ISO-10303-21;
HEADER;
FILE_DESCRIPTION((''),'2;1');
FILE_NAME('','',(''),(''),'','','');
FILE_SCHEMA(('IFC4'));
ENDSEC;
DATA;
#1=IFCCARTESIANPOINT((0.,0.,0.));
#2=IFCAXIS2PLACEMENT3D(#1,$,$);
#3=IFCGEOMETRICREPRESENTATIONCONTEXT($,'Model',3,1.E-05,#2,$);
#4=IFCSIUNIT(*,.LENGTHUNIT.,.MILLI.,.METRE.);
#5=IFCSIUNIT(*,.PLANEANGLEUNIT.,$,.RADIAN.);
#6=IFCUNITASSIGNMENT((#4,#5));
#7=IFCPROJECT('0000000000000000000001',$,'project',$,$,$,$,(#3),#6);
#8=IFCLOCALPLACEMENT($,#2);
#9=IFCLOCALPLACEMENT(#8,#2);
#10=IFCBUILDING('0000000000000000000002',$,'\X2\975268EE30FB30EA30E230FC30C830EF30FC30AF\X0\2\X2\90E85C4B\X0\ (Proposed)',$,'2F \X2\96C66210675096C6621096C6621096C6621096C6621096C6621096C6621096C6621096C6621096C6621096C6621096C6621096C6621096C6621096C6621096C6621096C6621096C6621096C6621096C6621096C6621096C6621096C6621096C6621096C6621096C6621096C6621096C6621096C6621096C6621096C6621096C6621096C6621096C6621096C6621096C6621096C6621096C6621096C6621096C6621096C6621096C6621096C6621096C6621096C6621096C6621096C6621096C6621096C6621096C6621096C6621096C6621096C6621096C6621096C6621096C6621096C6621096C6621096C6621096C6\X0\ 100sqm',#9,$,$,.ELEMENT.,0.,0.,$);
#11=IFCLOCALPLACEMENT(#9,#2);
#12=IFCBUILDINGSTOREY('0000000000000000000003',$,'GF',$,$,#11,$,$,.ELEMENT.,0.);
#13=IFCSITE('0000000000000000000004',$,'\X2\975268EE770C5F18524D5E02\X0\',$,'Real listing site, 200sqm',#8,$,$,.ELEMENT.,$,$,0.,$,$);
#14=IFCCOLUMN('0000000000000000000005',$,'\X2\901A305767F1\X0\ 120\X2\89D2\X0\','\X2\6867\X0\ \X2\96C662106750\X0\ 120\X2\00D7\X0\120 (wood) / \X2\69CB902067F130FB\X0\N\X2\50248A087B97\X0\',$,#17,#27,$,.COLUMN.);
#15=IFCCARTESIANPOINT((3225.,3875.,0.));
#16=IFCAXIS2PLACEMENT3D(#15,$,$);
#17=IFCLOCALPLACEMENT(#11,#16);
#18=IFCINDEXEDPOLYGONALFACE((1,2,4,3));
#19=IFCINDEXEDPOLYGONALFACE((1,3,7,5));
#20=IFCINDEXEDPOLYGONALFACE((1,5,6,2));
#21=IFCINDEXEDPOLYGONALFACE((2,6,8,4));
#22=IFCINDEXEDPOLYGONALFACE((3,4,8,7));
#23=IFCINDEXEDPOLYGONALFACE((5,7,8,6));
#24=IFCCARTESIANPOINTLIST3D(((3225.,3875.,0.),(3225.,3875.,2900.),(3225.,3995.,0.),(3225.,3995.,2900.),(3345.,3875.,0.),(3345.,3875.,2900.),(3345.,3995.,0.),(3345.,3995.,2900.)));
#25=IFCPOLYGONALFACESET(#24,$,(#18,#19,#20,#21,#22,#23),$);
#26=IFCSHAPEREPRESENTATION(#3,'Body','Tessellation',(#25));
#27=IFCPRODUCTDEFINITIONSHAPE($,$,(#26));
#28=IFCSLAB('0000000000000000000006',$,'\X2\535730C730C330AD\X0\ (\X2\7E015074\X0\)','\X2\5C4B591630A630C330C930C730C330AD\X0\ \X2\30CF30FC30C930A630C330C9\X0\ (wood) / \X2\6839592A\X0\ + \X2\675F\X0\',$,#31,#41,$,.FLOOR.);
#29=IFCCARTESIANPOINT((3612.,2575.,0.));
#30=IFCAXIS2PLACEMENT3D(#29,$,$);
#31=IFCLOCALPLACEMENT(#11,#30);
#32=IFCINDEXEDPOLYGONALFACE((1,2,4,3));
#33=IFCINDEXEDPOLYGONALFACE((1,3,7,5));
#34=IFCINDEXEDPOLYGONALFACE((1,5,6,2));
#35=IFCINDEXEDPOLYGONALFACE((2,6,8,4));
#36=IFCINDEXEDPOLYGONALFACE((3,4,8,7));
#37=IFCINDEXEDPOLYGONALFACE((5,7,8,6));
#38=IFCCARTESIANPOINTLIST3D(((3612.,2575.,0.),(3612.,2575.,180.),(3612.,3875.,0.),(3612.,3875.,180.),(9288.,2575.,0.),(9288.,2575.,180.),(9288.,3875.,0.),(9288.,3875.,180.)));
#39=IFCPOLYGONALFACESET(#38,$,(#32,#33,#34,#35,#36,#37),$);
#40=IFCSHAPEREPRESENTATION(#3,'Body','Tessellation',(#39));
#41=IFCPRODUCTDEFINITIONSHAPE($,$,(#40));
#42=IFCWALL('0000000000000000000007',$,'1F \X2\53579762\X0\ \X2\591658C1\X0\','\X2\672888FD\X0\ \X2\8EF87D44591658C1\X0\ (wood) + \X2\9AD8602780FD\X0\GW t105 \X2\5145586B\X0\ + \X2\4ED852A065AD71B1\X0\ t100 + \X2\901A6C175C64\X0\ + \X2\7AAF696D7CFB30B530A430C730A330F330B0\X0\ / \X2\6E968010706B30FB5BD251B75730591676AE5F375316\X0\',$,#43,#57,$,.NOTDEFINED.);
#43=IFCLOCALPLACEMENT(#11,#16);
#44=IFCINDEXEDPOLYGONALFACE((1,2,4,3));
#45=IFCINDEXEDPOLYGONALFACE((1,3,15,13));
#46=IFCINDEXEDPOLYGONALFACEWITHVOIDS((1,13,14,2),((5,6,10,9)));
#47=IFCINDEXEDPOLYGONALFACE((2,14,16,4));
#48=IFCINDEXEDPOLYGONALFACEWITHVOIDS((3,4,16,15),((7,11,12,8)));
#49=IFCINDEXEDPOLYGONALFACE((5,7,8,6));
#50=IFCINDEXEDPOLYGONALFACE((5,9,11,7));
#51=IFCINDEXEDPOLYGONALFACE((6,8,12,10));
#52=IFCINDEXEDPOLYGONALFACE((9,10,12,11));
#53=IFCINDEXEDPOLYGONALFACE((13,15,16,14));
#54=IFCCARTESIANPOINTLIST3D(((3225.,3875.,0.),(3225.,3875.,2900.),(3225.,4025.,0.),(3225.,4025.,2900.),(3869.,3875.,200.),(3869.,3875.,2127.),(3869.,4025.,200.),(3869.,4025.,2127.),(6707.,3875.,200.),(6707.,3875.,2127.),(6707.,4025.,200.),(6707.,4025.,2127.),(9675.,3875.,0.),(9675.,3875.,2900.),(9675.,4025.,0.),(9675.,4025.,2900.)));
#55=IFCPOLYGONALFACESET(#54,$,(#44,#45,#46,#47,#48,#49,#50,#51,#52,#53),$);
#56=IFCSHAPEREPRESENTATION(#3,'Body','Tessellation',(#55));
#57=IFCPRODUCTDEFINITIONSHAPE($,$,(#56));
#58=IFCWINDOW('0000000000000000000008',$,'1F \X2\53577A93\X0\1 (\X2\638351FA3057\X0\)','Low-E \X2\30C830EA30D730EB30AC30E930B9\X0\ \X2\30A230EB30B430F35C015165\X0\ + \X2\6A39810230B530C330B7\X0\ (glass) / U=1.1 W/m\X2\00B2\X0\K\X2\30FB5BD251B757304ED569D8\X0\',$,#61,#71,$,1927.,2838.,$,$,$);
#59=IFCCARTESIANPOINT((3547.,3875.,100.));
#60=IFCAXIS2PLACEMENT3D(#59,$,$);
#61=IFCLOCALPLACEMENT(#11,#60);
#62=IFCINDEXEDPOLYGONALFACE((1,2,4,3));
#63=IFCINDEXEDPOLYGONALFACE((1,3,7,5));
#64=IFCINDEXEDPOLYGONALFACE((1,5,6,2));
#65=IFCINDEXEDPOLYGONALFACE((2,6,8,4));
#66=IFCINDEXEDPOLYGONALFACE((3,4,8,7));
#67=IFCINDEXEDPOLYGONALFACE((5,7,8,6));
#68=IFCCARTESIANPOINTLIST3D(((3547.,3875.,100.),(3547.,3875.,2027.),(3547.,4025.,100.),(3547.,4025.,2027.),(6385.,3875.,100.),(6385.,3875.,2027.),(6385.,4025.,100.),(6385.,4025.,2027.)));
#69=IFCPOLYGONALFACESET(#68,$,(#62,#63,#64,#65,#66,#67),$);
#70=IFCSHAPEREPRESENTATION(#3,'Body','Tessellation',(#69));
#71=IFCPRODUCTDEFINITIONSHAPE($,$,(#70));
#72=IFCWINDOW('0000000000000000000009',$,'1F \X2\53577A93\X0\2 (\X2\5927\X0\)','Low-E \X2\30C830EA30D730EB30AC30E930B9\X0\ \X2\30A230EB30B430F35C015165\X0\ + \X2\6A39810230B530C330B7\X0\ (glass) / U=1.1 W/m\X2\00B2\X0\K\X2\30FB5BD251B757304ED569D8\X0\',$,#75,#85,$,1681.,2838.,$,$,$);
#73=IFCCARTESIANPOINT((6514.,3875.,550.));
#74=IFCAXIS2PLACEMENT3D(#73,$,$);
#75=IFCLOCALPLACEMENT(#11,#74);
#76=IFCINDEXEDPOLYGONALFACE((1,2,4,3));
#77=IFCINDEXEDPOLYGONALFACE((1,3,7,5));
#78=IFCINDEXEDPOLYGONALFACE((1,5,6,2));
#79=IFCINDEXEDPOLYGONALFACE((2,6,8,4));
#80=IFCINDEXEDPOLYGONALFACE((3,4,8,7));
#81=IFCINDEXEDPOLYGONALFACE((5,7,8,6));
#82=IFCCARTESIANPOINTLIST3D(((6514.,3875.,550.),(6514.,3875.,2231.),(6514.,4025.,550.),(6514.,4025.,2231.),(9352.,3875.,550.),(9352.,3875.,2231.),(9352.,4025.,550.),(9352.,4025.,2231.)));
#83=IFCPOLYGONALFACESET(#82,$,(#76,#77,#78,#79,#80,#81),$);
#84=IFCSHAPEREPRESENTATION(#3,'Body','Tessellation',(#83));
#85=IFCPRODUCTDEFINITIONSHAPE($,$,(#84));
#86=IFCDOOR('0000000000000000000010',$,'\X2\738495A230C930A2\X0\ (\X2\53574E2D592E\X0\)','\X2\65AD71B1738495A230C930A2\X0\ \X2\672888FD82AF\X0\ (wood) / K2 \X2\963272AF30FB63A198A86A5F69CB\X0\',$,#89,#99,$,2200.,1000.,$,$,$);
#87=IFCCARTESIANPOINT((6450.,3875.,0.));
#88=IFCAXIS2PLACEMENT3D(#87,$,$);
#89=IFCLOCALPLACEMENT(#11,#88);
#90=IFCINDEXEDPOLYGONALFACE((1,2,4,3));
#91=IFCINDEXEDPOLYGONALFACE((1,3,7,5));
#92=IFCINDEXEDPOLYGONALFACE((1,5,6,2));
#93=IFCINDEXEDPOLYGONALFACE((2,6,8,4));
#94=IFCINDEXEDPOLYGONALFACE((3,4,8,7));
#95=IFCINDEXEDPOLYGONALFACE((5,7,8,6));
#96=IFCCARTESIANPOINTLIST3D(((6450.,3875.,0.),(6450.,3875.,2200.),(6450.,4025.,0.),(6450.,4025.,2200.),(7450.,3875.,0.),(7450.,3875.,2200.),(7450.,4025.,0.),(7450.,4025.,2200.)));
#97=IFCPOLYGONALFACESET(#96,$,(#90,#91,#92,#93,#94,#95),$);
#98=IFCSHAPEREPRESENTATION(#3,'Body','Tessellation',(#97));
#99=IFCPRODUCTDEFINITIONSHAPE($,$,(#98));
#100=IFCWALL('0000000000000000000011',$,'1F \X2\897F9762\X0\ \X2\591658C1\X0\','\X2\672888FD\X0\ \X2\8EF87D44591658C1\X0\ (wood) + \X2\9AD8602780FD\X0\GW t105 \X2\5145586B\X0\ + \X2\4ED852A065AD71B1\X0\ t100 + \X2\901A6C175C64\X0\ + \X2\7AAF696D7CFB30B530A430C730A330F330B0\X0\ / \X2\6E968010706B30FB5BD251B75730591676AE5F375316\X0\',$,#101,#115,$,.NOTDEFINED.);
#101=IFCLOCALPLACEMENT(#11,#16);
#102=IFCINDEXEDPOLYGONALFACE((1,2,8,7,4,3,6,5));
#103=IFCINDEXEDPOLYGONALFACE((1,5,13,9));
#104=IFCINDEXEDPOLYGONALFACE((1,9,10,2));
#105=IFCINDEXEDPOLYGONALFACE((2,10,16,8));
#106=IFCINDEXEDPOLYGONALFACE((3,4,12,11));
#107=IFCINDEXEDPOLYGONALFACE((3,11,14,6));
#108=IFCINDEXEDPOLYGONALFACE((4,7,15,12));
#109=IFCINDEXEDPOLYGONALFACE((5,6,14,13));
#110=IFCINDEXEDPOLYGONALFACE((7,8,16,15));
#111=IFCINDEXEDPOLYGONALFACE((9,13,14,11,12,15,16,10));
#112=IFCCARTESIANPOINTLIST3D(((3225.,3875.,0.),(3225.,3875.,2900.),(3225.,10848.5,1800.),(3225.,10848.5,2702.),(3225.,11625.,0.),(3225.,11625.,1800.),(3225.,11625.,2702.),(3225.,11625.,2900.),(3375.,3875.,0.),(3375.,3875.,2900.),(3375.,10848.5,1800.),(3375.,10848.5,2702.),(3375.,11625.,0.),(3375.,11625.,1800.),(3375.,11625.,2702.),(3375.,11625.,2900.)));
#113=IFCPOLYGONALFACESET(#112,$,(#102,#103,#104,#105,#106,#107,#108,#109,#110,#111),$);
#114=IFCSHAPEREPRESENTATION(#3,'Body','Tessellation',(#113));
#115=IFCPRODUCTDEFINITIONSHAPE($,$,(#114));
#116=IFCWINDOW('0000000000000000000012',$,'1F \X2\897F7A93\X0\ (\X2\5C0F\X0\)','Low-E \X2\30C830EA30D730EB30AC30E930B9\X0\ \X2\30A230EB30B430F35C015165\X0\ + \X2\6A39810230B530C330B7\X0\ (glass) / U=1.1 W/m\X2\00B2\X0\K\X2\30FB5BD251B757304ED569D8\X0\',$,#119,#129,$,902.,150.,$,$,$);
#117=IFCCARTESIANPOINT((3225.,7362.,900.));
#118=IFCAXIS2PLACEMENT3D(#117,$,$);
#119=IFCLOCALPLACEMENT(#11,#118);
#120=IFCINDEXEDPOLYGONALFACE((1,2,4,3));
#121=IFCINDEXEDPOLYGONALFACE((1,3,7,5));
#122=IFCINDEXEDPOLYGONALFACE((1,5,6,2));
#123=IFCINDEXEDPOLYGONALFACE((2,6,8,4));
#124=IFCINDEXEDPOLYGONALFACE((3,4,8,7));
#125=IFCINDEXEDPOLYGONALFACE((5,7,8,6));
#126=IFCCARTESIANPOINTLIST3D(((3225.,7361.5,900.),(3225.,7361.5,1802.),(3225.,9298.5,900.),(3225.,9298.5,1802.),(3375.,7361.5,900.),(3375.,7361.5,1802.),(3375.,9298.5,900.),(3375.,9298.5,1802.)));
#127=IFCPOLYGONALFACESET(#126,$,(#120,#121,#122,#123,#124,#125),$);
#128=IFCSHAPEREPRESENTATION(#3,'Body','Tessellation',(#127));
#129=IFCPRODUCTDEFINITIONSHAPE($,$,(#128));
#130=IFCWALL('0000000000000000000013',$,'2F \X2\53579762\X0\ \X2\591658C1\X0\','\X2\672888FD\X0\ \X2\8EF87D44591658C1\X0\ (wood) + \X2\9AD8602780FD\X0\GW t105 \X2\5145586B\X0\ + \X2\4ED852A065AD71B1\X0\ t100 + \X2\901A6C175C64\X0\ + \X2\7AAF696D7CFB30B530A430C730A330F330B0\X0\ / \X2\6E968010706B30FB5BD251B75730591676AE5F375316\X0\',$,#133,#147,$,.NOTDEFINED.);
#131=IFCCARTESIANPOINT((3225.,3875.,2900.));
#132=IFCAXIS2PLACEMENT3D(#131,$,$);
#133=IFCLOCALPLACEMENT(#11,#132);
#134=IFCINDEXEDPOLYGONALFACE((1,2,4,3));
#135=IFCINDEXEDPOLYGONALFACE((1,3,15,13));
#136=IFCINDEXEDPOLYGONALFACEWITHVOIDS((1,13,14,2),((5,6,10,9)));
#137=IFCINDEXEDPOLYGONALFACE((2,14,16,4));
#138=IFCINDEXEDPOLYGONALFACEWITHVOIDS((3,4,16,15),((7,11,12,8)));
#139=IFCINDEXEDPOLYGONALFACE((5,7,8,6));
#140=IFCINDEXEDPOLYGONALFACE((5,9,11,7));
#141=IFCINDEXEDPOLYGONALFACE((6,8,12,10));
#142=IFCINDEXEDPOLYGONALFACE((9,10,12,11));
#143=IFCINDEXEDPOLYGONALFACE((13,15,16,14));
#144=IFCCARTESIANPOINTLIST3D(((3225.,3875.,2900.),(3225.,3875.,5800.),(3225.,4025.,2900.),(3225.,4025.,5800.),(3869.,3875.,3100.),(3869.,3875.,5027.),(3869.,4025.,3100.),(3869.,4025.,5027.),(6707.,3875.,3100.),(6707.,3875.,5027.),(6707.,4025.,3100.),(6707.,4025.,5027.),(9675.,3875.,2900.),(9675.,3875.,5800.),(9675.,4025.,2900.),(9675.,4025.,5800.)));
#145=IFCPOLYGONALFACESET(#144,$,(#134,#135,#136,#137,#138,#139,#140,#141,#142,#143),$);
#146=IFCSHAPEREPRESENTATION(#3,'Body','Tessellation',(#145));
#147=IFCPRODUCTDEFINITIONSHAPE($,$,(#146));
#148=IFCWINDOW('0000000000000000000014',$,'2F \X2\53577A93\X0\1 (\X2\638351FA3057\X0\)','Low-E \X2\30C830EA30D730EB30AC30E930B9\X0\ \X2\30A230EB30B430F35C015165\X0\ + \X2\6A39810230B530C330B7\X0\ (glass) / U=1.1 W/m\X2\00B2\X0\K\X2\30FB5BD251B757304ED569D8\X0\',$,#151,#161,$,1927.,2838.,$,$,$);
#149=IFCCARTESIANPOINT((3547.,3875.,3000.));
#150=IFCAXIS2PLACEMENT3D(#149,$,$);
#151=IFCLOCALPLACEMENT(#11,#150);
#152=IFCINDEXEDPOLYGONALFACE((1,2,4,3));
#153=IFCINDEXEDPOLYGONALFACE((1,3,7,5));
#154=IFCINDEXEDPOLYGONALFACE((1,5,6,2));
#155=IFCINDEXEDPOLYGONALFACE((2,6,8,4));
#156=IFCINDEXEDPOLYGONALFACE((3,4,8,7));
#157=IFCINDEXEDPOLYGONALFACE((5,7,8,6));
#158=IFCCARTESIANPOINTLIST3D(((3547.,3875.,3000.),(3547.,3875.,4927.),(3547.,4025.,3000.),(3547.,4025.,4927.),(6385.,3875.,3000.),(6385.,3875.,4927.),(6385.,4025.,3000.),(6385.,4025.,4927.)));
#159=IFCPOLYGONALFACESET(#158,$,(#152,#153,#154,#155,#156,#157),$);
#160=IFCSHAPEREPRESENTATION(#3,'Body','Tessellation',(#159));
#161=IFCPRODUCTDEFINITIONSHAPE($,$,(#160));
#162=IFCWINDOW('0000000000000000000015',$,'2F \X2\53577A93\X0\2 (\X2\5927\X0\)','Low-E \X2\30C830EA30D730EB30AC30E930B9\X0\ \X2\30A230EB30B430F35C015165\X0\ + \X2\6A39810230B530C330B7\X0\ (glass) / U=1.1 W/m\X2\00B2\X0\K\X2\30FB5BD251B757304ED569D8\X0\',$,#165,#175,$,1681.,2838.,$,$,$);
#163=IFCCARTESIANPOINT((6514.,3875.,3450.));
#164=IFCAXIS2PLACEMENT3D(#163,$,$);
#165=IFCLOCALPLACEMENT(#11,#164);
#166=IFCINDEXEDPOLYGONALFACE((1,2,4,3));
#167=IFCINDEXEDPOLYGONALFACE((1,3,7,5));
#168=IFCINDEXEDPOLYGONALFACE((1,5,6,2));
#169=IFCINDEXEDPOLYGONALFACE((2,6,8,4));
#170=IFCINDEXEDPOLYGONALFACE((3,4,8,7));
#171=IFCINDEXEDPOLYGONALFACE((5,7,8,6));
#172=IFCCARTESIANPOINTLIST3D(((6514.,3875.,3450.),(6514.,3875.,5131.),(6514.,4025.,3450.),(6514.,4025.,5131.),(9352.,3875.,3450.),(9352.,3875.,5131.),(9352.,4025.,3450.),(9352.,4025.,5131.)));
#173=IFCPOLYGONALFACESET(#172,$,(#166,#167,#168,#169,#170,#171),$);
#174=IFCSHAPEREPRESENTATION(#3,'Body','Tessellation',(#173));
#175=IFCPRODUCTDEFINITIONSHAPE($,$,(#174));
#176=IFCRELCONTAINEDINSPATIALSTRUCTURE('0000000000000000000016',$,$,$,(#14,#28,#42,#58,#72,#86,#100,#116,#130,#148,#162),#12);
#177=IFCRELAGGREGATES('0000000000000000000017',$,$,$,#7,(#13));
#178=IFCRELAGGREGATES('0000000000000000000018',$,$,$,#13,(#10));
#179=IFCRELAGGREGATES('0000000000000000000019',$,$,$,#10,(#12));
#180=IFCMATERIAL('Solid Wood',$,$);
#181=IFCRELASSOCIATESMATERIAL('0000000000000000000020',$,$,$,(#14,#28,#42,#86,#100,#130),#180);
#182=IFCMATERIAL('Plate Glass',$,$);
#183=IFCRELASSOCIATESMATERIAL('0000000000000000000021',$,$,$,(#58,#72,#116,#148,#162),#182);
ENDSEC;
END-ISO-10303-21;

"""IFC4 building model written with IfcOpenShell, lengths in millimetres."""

from ifc_helpers import new_model, si_unit, frame, frame_2d, origin, place, context, project, spatial, rectangle, extrude, material, element, fill, save


model = new_model("IFC4")

# Units and contexts
model_context = context("Model", 3, precision=1e-05, world=origin())
ifc_project = project(units=[si_unit("LENGTHUNIT", "METRE", prefix="MILLI"), si_unit("PLANEANGLEUNIT", "RADIAN")], contexts=[model_context])

# Site, building, storey
site_placement = place(None, origin())
site = spatial("IfcSite", under=ifc_project, at=site_placement, Name="青森県弘前市", ObjectType="Real listing site, 200sqm", CompositionType="ELEMENT", RefElevation=0.0)
building_placement = place(site_placement, origin())
building = spatial("IfcBuilding", under=site, at=building_placement, Name="青森・リモートワーク2部屋 (Proposed)", ObjectType="2F 集成材集成集成集成集成集成集成集成集成集成集成集成集成集成集成集成集成集成集成集成集成集成集成集成集成集成集成集成集成集成集成集成集成集成集成集成集成集成集成集成集成集成集成集成集成集成集成集成集成集成集成集成集成集成集成集成集成集成集成集 100sqm", CompositionType="ELEMENT", ElevationOfRefHeight=0.0, ElevationOfTerrain=0.0)
storey_placement = place(building_placement, origin())
storey = spatial("IfcBuildingStorey", under=building, at=storey_placement, Name="GF", CompositionType="ELEMENT", Elevation=0.0)

# Column
ifc_material_1 = material(Name="Solid Wood")
column_placement = place(storey_placement, frame((3225.0, 3875.0, 0.0)))
element("IfcColumn", 1, at=column_placement, inside=storey, material=ifc_material_1, Name="通し柱 120角", Description="桧 集成材 120×120 (wood) / 構造柱・N値計算", PredefinedType="COLUMN", context=model_context, shape_type="SweptSolid", body=[
    extrude(rectangle(XDim=120.0, YDim=120.0, at=frame_2d((60.0, 60.0))), frame((3225.0, 3875.0, 0.0)), (0.0, 0.0, 1.0), 2900.0),
])

# Slab
slab_1_placement = place(storey_placement, frame((3612.0, 2575.0, 0.0)))
element("IfcSlab", 2, at=slab_1_placement, inside=storey, material=ifc_material_1, Name="南デッキ (縁側)", Description="屋外ウッドデッキ ハードウッド (wood) / 根太 + 束", PredefinedType="FLOOR", context=model_context, shape_type="SweptSolid", body=[
    extrude(rectangle(XDim=5676.0, YDim=1300.0, at=frame_2d((2838.0, 650.0))), frame((3612.0, 2575.0, 0.0)), (0.0, 0.0, 1.0), 180.0),
])

# Wall, openings, windows, door
wall_1_placement = place(storey_placement, frame((3225.0, 3875.0, 0.0)))
wall_1 = element("IfcWall", 3, at=wall_1_placement, inside=storey, material=ifc_material_1, Name="1F 南面 外壁", Description="木製 軸組外壁 (wood) + 高性能GW t105 充填 + 付加断熱 t100 + 通気層 + 窯業系サイディング / 準耐火・寒冷地外皮強化", PredefinedType="NOTDEFINED", context=model_context, shape_type="SweptSolid", body=[
    extrude(rectangle(XDim=6450.0, YDim=150.0, at=frame_2d((3225.0, 75.0))), frame((3225.0, 3875.0, 0.0)), (0.0, 0.0, 1.0), 2900.0),
])
opening_1_placement = place(storey_placement, frame((3547.0, 3875.0, 100.0)))
opening_1 = element("IfcOpeningElement", 4, at=opening_1_placement, cuts=wall_1, PredefinedType="NOTDEFINED", context=model_context, shape_type="SweptSolid", body=[
    extrude(rectangle(XDim=2838.0, YDim=150.0, at=frame_2d((1419.0, 75.0))), frame((3547.0, 3875.0, 100.0)), (0.0, 0.0, 1.0), 1927.0),
])
opening_2_placement = place(storey_placement, frame((6514.0, 3875.0, 550.0)))
opening_2 = element("IfcOpeningElement", 5, at=opening_2_placement, cuts=wall_1, PredefinedType="NOTDEFINED", context=model_context, shape_type="SweptSolid", body=[
    extrude(rectangle(XDim=2838.0, YDim=150.0, at=frame_2d((1419.0, 75.0))), frame((6514.0, 3875.0, 550.0)), (0.0, 0.0, 1.0), 1681.0),
])
opening_3_placement = place(storey_placement, frame((6450.0, 3875.0, 0.0)))
opening_3 = element("IfcOpeningElement", 6, at=opening_3_placement, cuts=wall_1, PredefinedType="NOTDEFINED", context=model_context, shape_type="SweptSolid", body=[
    extrude(rectangle(XDim=1000.0, YDim=150.0, at=frame_2d((500.0, 75.0))), frame((6450.0, 3875.0, 0.0)), (0.0, 0.0, 1.0), 2200.0),
])
ifc_material_2 = material(Name="Plate Glass")
window_1_placement = place(storey_placement, frame((3547.0, 3875.0, 100.0)))
window_1 = element("IfcWindow", 7, at=window_1_placement, inside=storey, material=ifc_material_2, Name="1F 南窓1 (掃出し)", Description="Low-E トリプルガラス アルゴン封入 + 樹脂サッシ (glass) / U=1.1 W/m²K・寒冷地仕様", OverallHeight=1927.0, OverallWidth=2838.0, context=model_context, shape_type="SweptSolid", body=[
    extrude(rectangle(XDim=2838.0, YDim=150.0, at=frame_2d((1419.0, 75.0))), frame((3547.0, 3875.0, 100.0)), (0.0, 0.0, 1.0), 1927.0),
])
fill(opening_1, window_1)
window_2_placement = place(storey_placement, frame((6514.0, 3875.0, 550.0)))
window_2 = element("IfcWindow", 8, at=window_2_placement, inside=storey, material=ifc_material_2, Name="1F 南窓2 (大)", Description="Low-E トリプルガラス アルゴン封入 + 樹脂サッシ (glass) / U=1.1 W/m²K・寒冷地仕様", OverallHeight=1681.0, OverallWidth=2838.0, context=model_context, shape_type="SweptSolid", body=[
    extrude(rectangle(XDim=2838.0, YDim=150.0, at=frame_2d((1419.0, 75.0))), frame((6514.0, 3875.0, 550.0)), (0.0, 0.0, 1.0), 1681.0),
])
fill(opening_2, window_2)
door_placement = place(storey_placement, frame((6450.0, 3875.0, 0.0)))
door = element("IfcDoor", 9, at=door_placement, inside=storey, material=ifc_material_1, Name="玄関ドア (南中央)", Description="断熱玄関ドア 木製芯 (wood) / K2 防犯・採風機構", OverallHeight=2200.0, OverallWidth=1000.0, context=model_context, shape_type="SweptSolid", body=[
    extrude(rectangle(XDim=1000.0, YDim=150.0, at=frame_2d((500.0, 75.0))), frame((6450.0, 3875.0, 0.0)), (0.0, 0.0, 1.0), 2200.0),
])
fill(opening_3, door)

# Wall, opening, window
wall_2_placement = place(storey_placement, frame((3225.0, 3875.0, 0.0)))
wall_2 = element("IfcWall", 10, at=wall_2_placement, inside=storey, material=ifc_material_1, Name="1F 西面 外壁", Description="木製 軸組外壁 (wood) + 高性能GW t105 充填 + 付加断熱 t100 + 通気層 + 窯業系サイディング / 準耐火・寒冷地外皮強化", PredefinedType="NOTDEFINED", context=model_context, shape_type="SweptSolid", body=[
    extrude(rectangle(XDim=150.0, YDim=7750.0, at=frame_2d((75.0, 3875.0))), frame((3225.0, 3875.0, 0.0)), (0.0, 0.0, 1.0), 2900.0),
])
opening_4_placement = place(storey_placement, frame((3225.0, 7362.0, 900.0)))
opening_4 = element("IfcOpeningElement", 11, at=opening_4_placement, cuts=wall_2, PredefinedType="NOTDEFINED", context=model_context, shape_type="SweptSolid", body=[
    extrude(rectangle(XDim=150.0, YDim=1937.0, at=frame_2d((75.0, 968.0))), frame((3225.0, 7362.0, 900.0)), (0.0, 0.0, 1.0), 902.0),
])
window_3_placement = place(storey_placement, frame((3225.0, 7362.0, 900.0)))
window_3 = element("IfcWindow", 12, at=window_3_placement, inside=storey, material=ifc_material_2, Name="1F 西窓 (小)", Description="Low-E トリプルガラス アルゴン封入 + 樹脂サッシ (glass) / U=1.1 W/m²K・寒冷地仕様", OverallHeight=902.0, OverallWidth=150.0, context=model_context, shape_type="SweptSolid", body=[
    extrude(rectangle(XDim=150.0, YDim=1937.0, at=frame_2d((75.0, 968.0))), frame((3225.0, 7362.0, 900.0)), (0.0, 0.0, 1.0), 902.0),
])
fill(opening_4, window_3)

# Wall, openings, windows
wall_3_placement = place(storey_placement, frame((3225.0, 3875.0, 2900.0)))
wall_3 = element("IfcWall", 13, at=wall_3_placement, inside=storey, material=ifc_material_1, Name="2F 南面 外壁", Description="木製 軸組外壁 (wood) + 高性能GW t105 充填 + 付加断熱 t100 + 通気層 + 窯業系サイディング / 準耐火・寒冷地外皮強化", PredefinedType="NOTDEFINED", context=model_context, shape_type="SweptSolid", body=[
    extrude(rectangle(XDim=6450.0, YDim=150.0, at=frame_2d((3225.0, 75.0))), frame((3225.0, 3875.0, 2900.0)), (0.0, 0.0, 1.0), 2900.0),
])
opening_5_placement = place(storey_placement, frame((3547.0, 3875.0, 3000.0)))
opening_5 = element("IfcOpeningElement", 14, at=opening_5_placement, cuts=wall_3, PredefinedType="NOTDEFINED", context=model_context, shape_type="SweptSolid", body=[
    extrude(rectangle(XDim=2838.0, YDim=150.0, at=frame_2d((1419.0, 75.0))), frame((3547.0, 3875.0, 3000.0)), (0.0, 0.0, 1.0), 1927.0),
])
opening_6_placement = place(storey_placement, frame((6514.0, 3875.0, 3450.0)))
opening_6 = element("IfcOpeningElement", 15, at=opening_6_placement, cuts=wall_3, PredefinedType="NOTDEFINED", context=model_context, shape_type="SweptSolid", body=[
    extrude(rectangle(XDim=2838.0, YDim=150.0, at=frame_2d((1419.0, 75.0))), frame((6514.0, 3875.0, 3450.0)), (0.0, 0.0, 1.0), 1681.0),
])
window_4_placement = place(storey_placement, frame((3547.0, 3875.0, 3000.0)))
window_4 = element("IfcWindow", 16, at=window_4_placement, inside=storey, material=ifc_material_2, Name="2F 南窓1 (掃出し)", Description="Low-E トリプルガラス アルゴン封入 + 樹脂サッシ (glass) / U=1.1 W/m²K・寒冷地仕様", OverallHeight=1927.0, OverallWidth=2838.0, context=model_context, shape_type="SweptSolid", body=[
    extrude(rectangle(XDim=2838.0, YDim=150.0, at=frame_2d((1419.0, 75.0))), frame((3547.0, 3875.0, 3000.0)), (0.0, 0.0, 1.0), 1927.0),
])
fill(opening_5, window_4)
window_5_placement = place(storey_placement, frame((6514.0, 3875.0, 3450.0)))
window_5 = element("IfcWindow", 17, at=window_5_placement, inside=storey, material=ifc_material_2, Name="2F 南窓2 (大)", Description="Low-E トリプルガラス アルゴン封入 + 樹脂サッシ (glass) / U=1.1 W/m²K・寒冷地仕様", OverallHeight=1681.0, OverallWidth=2838.0, context=model_context, shape_type="SweptSolid", body=[
    extrude(rectangle(XDim=2838.0, YDim=150.0, at=frame_2d((1419.0, 75.0))), frame((6514.0, 3875.0, 3450.0)), (0.0, 0.0, 1.0), 1681.0),
])
fill(opening_6, window_5)

save(model, "model.ifc")
